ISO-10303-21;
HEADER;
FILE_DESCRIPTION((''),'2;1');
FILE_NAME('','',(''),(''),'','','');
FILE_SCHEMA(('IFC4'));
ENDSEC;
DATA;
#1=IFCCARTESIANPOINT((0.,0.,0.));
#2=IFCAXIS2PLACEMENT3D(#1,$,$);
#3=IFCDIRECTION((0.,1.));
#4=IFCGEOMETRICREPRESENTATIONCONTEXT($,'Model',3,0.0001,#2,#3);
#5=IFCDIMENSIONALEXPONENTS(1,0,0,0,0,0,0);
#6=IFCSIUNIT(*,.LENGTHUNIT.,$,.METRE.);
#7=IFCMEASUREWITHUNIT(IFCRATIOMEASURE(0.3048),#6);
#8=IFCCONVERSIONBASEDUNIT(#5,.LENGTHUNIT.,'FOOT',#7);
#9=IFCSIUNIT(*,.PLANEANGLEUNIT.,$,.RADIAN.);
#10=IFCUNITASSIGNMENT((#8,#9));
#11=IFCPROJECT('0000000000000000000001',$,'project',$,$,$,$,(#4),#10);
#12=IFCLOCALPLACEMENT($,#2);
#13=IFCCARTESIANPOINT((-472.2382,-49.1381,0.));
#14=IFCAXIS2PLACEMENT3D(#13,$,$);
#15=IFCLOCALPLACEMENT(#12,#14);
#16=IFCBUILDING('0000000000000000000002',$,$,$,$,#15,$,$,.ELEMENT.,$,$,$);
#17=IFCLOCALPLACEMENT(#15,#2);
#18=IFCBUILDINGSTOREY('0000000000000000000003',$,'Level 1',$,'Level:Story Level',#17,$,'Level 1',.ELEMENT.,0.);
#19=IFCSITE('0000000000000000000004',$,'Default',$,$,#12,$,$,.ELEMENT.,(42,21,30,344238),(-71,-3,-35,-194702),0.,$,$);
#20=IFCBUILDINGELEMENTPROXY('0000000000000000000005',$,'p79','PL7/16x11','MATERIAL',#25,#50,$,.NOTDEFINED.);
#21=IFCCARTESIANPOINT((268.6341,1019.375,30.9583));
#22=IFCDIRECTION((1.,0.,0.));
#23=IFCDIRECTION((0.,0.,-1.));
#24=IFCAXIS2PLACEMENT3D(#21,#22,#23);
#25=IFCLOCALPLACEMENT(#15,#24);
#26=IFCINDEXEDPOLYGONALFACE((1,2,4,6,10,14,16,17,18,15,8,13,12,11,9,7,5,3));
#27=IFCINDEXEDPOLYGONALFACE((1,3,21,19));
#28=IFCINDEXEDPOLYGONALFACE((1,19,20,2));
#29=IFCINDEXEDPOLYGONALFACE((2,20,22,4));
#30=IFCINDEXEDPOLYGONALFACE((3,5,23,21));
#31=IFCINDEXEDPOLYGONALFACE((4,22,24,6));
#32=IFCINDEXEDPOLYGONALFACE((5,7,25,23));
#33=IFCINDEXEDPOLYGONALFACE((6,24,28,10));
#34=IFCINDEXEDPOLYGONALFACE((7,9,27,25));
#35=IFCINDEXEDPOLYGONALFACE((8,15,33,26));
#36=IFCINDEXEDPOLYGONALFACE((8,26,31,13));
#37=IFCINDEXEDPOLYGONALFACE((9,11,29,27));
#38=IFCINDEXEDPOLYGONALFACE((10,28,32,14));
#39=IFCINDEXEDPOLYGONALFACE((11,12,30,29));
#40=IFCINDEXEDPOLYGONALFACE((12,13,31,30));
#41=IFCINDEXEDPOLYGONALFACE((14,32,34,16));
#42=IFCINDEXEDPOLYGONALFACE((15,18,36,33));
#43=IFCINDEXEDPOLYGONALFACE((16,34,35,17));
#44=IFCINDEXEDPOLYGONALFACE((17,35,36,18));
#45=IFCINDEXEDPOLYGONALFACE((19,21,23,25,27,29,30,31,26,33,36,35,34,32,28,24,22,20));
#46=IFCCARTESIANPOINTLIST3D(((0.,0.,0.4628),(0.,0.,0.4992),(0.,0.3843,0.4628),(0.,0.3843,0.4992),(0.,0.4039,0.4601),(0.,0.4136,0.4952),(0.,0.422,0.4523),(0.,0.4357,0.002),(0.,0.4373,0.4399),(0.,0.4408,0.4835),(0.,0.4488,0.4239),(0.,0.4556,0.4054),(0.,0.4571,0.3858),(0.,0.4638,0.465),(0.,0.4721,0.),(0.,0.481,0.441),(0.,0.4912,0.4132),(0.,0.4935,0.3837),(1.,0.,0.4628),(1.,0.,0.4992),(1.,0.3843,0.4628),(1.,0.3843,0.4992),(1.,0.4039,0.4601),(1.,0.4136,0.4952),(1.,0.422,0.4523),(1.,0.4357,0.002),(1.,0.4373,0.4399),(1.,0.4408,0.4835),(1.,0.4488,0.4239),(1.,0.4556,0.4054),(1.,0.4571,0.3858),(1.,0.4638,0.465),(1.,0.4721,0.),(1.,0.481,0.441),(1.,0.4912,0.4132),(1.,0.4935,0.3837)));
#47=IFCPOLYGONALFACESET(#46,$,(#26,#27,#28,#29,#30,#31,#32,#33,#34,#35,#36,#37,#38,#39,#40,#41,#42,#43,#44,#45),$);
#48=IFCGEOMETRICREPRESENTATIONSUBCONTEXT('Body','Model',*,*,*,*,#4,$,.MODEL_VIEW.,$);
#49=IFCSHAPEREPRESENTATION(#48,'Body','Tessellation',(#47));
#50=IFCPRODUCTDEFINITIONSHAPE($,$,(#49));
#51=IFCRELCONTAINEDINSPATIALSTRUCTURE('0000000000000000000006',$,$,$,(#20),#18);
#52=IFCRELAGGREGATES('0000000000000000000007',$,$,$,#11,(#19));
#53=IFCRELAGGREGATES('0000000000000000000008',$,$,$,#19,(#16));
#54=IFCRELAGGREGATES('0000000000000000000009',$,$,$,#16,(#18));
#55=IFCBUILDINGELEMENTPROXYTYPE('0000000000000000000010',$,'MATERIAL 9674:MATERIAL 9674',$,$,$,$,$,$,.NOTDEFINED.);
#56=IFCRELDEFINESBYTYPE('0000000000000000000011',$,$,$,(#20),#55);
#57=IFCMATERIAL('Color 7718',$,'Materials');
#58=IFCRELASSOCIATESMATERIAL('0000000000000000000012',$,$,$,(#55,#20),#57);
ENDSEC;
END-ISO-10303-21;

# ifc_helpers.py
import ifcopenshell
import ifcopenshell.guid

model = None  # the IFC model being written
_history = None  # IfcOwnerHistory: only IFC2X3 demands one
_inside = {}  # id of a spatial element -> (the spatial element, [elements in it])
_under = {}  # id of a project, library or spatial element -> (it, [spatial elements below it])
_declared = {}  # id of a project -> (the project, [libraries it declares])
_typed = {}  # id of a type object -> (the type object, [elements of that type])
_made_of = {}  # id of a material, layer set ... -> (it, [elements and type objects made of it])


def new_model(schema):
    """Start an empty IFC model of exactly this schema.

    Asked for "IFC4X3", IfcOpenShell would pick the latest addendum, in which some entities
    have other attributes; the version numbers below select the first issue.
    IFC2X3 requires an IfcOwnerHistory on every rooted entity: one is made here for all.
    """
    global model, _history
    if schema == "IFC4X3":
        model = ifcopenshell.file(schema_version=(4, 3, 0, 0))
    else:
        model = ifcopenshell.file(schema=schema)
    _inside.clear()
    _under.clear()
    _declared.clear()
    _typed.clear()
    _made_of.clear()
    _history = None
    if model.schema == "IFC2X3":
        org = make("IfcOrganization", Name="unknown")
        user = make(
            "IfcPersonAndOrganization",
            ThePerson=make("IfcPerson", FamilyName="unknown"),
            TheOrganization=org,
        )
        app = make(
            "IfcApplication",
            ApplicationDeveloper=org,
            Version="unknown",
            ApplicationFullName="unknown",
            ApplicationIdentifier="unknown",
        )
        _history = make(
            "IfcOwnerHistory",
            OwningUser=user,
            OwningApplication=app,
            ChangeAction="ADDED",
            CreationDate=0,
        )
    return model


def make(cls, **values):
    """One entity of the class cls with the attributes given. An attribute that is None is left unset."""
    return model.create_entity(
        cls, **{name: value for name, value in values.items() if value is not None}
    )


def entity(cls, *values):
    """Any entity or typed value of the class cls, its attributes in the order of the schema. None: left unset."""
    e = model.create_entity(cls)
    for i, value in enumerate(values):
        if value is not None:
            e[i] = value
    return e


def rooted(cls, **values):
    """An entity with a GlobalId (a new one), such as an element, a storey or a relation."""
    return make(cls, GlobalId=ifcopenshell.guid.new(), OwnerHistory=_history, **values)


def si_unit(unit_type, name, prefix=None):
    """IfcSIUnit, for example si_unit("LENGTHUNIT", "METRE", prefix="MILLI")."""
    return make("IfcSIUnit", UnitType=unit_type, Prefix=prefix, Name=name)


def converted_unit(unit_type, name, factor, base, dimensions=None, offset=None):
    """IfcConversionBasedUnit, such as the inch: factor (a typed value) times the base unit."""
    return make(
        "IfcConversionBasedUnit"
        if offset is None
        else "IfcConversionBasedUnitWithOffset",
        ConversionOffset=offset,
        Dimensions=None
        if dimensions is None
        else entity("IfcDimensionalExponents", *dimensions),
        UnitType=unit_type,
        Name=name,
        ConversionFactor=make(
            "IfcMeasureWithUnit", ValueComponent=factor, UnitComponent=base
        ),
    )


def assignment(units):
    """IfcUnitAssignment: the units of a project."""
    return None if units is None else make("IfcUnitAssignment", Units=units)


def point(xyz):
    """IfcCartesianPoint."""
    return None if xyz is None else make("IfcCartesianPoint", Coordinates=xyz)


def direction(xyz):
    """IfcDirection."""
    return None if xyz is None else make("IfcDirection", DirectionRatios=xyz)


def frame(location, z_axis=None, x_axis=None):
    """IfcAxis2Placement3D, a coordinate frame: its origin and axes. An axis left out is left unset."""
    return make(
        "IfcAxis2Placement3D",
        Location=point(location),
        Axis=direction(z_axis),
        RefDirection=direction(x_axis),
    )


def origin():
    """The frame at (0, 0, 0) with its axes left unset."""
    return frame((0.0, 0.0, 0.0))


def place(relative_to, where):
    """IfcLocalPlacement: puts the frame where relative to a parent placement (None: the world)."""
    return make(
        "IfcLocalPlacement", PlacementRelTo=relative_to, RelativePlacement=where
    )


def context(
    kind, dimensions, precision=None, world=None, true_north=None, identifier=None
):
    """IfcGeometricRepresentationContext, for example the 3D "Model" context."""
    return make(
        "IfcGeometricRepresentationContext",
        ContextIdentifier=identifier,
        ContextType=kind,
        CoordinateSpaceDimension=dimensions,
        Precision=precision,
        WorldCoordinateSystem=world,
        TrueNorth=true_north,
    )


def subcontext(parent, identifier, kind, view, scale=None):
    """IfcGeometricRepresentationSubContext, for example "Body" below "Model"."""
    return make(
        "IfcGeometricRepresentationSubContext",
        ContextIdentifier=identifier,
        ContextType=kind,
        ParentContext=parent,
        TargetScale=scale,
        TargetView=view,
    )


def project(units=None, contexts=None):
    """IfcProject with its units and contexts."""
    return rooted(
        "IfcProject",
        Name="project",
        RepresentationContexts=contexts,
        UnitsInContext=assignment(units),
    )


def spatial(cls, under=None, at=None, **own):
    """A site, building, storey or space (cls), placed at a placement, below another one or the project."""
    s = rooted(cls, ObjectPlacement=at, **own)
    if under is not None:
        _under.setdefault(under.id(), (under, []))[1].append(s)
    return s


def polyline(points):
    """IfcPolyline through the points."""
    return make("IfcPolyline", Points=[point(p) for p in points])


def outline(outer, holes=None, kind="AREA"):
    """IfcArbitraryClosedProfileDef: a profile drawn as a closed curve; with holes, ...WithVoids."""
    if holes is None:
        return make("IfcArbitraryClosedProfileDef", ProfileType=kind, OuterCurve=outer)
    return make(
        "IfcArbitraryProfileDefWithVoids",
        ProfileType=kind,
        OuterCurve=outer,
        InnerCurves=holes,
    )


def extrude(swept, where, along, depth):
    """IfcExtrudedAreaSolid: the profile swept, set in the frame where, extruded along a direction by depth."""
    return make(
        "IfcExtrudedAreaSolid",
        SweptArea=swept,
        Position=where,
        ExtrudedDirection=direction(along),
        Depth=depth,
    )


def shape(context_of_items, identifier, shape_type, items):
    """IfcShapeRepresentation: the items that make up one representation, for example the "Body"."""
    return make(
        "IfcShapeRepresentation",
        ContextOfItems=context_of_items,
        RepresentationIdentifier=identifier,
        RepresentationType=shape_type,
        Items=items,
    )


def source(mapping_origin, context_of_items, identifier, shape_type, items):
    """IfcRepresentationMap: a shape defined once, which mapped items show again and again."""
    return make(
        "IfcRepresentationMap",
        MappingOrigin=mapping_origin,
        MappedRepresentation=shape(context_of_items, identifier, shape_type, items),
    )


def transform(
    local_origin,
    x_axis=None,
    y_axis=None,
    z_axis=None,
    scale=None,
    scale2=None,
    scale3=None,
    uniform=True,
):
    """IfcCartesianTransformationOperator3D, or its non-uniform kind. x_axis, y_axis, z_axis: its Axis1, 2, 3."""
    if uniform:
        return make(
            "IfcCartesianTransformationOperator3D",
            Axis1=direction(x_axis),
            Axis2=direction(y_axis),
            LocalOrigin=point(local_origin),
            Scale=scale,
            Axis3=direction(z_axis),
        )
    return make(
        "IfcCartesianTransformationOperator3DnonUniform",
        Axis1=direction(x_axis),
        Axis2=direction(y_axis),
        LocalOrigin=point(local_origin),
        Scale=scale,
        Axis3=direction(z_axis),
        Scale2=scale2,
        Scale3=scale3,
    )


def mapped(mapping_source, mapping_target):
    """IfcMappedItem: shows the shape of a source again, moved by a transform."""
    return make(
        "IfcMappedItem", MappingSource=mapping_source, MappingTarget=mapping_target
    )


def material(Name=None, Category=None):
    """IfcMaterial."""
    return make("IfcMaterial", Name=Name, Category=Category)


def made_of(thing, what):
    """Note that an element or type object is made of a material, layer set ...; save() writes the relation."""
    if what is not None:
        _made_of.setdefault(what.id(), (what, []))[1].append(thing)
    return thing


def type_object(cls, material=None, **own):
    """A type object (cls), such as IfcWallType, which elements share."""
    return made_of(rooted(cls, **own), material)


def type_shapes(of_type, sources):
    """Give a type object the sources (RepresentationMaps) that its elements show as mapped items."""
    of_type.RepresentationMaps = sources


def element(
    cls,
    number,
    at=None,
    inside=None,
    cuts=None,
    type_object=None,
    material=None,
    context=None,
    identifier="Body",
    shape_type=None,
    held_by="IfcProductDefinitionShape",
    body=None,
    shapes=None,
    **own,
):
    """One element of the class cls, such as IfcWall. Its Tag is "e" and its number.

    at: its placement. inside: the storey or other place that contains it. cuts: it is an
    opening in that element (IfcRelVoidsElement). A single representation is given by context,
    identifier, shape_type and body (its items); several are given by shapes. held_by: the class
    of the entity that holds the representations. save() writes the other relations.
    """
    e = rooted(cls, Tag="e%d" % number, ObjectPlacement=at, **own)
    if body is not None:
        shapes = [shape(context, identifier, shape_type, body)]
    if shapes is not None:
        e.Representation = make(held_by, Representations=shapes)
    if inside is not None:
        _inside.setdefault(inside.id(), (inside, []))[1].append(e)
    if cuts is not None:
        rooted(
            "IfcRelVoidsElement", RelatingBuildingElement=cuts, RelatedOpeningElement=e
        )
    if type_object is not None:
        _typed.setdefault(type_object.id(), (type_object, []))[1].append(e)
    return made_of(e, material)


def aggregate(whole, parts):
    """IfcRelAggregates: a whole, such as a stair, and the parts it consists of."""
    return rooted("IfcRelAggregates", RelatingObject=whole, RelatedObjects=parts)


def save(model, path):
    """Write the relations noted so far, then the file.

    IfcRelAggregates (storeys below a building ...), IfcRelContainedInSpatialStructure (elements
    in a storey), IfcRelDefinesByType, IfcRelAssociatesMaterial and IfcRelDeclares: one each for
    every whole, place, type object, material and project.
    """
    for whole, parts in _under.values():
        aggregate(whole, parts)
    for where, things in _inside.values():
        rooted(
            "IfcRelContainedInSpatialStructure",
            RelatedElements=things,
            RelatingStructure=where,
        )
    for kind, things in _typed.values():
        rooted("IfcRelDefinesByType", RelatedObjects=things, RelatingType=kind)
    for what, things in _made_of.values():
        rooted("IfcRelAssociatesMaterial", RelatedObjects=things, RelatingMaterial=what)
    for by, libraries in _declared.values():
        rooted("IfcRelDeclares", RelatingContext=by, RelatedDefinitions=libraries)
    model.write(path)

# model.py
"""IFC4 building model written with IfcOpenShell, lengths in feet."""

from ifc_helpers import new_model, entity, si_unit, converted_unit, direction, frame, origin, place, context, subcontext, project, spatial, polyline, outline, extrude, source, transform, mapped, material, type_object, type_shapes, element, save


model = new_model("IFC4")

# Units and contexts
model_context = context("Model", 3, precision=0.0001, world=origin(), true_north=direction((0.0, 1.0)))
body_context = subcontext(model_context, "Body", "Model", "MODEL_VIEW")
ifc_project = project(units=[converted_unit("LENGTHUNIT", "FOOT", entity("IfcRatioMeasure", 0.3048), si_unit("LENGTHUNIT", "METRE"), dimensions=[1, 0, 0, 0, 0, 0, 0]), si_unit("PLANEANGLEUNIT", "RADIAN")], contexts=[model_context])

# Site, building, storey
site_placement = place(None, origin())
site = spatial("IfcSite", under=ifc_project, at=site_placement, Name="Default", CompositionType="ELEMENT", RefLatitude=(42, 21, 30, 344238), RefLongitude=(-71, -3, -35, -194702), RefElevation=0.0)
building_placement = place(site_placement, frame((-472.2382, -49.1381, 0.0)))
building = spatial("IfcBuilding", under=site, at=building_placement, CompositionType="ELEMENT")
storey_placement = place(building_placement, origin())
storey = spatial("IfcBuildingStorey", under=building, at=storey_placement, Name="Level 1", ObjectType="Level:Story Level", LongName="Level 1", CompositionType="ELEMENT", Elevation=0.0)

# Building element proxy
ifc_material_1 = material(Name="Color 7718", Category="Materials")
building_element_proxy_type_1 = type_object("IfcBuildingElementProxyType", Name="MATERIAL 9674:MATERIAL 9674", PredefinedType="NOTDEFINED", material=ifc_material_1)
shared_shape_1 = source(origin(), body_context, "Body", "SweptSolid", [
    extrude(outline(polyline([(0.0093, -0.1006), (0.3936, -0.1006), (0.3936, -0.0641), (0.0093, -0.0641), (-0.0102, -0.0615), (-0.0283, -0.0537), (-0.0437, -0.0413), (-0.0552, -0.0253), (-0.062, -0.0068), (-0.0635, 0.0128), (-0.0421, 0.3966), (-0.0785, 0.3986), (-0.0999, 0.0149), (-0.0976, -0.0146), (-0.0874, -0.0424), (-0.0702, -0.0664), (-0.0472, -0.0849), (-0.02, -0.0966), (0.0093, -0.1006)])), frame((0.0, 0.3936, 0.3986), z_axis=(1.0, 0.0, 0.0), x_axis=(0.0, -1.0, 0.0)), (0.0, 0.0, 1.0), 1.0),
])
type_shapes(building_element_proxy_type_1, [shared_shape_1])
proxy_1_placement = place(building_placement, frame((268.6341, 1019.375, 30.9583), z_axis=(1.0, 0.0, 0.0), x_axis=(0.0, 0.0, -1.0)))
element("IfcBuildingElementProxy", 1, at=proxy_1_placement, inside=storey, type_object=building_element_proxy_type_1, material=ifc_material_1, Name="p79", Description="PL7/16x11", ObjectType="MATERIAL", PredefinedType="NOTDEFINED", context=body_context, shape_type="MappedRepresentation", body=[
    mapped(shared_shape_1, transform((0.0, 0.0, 0.0), scale=1.0)),
])

save(model, "model.ifc")
